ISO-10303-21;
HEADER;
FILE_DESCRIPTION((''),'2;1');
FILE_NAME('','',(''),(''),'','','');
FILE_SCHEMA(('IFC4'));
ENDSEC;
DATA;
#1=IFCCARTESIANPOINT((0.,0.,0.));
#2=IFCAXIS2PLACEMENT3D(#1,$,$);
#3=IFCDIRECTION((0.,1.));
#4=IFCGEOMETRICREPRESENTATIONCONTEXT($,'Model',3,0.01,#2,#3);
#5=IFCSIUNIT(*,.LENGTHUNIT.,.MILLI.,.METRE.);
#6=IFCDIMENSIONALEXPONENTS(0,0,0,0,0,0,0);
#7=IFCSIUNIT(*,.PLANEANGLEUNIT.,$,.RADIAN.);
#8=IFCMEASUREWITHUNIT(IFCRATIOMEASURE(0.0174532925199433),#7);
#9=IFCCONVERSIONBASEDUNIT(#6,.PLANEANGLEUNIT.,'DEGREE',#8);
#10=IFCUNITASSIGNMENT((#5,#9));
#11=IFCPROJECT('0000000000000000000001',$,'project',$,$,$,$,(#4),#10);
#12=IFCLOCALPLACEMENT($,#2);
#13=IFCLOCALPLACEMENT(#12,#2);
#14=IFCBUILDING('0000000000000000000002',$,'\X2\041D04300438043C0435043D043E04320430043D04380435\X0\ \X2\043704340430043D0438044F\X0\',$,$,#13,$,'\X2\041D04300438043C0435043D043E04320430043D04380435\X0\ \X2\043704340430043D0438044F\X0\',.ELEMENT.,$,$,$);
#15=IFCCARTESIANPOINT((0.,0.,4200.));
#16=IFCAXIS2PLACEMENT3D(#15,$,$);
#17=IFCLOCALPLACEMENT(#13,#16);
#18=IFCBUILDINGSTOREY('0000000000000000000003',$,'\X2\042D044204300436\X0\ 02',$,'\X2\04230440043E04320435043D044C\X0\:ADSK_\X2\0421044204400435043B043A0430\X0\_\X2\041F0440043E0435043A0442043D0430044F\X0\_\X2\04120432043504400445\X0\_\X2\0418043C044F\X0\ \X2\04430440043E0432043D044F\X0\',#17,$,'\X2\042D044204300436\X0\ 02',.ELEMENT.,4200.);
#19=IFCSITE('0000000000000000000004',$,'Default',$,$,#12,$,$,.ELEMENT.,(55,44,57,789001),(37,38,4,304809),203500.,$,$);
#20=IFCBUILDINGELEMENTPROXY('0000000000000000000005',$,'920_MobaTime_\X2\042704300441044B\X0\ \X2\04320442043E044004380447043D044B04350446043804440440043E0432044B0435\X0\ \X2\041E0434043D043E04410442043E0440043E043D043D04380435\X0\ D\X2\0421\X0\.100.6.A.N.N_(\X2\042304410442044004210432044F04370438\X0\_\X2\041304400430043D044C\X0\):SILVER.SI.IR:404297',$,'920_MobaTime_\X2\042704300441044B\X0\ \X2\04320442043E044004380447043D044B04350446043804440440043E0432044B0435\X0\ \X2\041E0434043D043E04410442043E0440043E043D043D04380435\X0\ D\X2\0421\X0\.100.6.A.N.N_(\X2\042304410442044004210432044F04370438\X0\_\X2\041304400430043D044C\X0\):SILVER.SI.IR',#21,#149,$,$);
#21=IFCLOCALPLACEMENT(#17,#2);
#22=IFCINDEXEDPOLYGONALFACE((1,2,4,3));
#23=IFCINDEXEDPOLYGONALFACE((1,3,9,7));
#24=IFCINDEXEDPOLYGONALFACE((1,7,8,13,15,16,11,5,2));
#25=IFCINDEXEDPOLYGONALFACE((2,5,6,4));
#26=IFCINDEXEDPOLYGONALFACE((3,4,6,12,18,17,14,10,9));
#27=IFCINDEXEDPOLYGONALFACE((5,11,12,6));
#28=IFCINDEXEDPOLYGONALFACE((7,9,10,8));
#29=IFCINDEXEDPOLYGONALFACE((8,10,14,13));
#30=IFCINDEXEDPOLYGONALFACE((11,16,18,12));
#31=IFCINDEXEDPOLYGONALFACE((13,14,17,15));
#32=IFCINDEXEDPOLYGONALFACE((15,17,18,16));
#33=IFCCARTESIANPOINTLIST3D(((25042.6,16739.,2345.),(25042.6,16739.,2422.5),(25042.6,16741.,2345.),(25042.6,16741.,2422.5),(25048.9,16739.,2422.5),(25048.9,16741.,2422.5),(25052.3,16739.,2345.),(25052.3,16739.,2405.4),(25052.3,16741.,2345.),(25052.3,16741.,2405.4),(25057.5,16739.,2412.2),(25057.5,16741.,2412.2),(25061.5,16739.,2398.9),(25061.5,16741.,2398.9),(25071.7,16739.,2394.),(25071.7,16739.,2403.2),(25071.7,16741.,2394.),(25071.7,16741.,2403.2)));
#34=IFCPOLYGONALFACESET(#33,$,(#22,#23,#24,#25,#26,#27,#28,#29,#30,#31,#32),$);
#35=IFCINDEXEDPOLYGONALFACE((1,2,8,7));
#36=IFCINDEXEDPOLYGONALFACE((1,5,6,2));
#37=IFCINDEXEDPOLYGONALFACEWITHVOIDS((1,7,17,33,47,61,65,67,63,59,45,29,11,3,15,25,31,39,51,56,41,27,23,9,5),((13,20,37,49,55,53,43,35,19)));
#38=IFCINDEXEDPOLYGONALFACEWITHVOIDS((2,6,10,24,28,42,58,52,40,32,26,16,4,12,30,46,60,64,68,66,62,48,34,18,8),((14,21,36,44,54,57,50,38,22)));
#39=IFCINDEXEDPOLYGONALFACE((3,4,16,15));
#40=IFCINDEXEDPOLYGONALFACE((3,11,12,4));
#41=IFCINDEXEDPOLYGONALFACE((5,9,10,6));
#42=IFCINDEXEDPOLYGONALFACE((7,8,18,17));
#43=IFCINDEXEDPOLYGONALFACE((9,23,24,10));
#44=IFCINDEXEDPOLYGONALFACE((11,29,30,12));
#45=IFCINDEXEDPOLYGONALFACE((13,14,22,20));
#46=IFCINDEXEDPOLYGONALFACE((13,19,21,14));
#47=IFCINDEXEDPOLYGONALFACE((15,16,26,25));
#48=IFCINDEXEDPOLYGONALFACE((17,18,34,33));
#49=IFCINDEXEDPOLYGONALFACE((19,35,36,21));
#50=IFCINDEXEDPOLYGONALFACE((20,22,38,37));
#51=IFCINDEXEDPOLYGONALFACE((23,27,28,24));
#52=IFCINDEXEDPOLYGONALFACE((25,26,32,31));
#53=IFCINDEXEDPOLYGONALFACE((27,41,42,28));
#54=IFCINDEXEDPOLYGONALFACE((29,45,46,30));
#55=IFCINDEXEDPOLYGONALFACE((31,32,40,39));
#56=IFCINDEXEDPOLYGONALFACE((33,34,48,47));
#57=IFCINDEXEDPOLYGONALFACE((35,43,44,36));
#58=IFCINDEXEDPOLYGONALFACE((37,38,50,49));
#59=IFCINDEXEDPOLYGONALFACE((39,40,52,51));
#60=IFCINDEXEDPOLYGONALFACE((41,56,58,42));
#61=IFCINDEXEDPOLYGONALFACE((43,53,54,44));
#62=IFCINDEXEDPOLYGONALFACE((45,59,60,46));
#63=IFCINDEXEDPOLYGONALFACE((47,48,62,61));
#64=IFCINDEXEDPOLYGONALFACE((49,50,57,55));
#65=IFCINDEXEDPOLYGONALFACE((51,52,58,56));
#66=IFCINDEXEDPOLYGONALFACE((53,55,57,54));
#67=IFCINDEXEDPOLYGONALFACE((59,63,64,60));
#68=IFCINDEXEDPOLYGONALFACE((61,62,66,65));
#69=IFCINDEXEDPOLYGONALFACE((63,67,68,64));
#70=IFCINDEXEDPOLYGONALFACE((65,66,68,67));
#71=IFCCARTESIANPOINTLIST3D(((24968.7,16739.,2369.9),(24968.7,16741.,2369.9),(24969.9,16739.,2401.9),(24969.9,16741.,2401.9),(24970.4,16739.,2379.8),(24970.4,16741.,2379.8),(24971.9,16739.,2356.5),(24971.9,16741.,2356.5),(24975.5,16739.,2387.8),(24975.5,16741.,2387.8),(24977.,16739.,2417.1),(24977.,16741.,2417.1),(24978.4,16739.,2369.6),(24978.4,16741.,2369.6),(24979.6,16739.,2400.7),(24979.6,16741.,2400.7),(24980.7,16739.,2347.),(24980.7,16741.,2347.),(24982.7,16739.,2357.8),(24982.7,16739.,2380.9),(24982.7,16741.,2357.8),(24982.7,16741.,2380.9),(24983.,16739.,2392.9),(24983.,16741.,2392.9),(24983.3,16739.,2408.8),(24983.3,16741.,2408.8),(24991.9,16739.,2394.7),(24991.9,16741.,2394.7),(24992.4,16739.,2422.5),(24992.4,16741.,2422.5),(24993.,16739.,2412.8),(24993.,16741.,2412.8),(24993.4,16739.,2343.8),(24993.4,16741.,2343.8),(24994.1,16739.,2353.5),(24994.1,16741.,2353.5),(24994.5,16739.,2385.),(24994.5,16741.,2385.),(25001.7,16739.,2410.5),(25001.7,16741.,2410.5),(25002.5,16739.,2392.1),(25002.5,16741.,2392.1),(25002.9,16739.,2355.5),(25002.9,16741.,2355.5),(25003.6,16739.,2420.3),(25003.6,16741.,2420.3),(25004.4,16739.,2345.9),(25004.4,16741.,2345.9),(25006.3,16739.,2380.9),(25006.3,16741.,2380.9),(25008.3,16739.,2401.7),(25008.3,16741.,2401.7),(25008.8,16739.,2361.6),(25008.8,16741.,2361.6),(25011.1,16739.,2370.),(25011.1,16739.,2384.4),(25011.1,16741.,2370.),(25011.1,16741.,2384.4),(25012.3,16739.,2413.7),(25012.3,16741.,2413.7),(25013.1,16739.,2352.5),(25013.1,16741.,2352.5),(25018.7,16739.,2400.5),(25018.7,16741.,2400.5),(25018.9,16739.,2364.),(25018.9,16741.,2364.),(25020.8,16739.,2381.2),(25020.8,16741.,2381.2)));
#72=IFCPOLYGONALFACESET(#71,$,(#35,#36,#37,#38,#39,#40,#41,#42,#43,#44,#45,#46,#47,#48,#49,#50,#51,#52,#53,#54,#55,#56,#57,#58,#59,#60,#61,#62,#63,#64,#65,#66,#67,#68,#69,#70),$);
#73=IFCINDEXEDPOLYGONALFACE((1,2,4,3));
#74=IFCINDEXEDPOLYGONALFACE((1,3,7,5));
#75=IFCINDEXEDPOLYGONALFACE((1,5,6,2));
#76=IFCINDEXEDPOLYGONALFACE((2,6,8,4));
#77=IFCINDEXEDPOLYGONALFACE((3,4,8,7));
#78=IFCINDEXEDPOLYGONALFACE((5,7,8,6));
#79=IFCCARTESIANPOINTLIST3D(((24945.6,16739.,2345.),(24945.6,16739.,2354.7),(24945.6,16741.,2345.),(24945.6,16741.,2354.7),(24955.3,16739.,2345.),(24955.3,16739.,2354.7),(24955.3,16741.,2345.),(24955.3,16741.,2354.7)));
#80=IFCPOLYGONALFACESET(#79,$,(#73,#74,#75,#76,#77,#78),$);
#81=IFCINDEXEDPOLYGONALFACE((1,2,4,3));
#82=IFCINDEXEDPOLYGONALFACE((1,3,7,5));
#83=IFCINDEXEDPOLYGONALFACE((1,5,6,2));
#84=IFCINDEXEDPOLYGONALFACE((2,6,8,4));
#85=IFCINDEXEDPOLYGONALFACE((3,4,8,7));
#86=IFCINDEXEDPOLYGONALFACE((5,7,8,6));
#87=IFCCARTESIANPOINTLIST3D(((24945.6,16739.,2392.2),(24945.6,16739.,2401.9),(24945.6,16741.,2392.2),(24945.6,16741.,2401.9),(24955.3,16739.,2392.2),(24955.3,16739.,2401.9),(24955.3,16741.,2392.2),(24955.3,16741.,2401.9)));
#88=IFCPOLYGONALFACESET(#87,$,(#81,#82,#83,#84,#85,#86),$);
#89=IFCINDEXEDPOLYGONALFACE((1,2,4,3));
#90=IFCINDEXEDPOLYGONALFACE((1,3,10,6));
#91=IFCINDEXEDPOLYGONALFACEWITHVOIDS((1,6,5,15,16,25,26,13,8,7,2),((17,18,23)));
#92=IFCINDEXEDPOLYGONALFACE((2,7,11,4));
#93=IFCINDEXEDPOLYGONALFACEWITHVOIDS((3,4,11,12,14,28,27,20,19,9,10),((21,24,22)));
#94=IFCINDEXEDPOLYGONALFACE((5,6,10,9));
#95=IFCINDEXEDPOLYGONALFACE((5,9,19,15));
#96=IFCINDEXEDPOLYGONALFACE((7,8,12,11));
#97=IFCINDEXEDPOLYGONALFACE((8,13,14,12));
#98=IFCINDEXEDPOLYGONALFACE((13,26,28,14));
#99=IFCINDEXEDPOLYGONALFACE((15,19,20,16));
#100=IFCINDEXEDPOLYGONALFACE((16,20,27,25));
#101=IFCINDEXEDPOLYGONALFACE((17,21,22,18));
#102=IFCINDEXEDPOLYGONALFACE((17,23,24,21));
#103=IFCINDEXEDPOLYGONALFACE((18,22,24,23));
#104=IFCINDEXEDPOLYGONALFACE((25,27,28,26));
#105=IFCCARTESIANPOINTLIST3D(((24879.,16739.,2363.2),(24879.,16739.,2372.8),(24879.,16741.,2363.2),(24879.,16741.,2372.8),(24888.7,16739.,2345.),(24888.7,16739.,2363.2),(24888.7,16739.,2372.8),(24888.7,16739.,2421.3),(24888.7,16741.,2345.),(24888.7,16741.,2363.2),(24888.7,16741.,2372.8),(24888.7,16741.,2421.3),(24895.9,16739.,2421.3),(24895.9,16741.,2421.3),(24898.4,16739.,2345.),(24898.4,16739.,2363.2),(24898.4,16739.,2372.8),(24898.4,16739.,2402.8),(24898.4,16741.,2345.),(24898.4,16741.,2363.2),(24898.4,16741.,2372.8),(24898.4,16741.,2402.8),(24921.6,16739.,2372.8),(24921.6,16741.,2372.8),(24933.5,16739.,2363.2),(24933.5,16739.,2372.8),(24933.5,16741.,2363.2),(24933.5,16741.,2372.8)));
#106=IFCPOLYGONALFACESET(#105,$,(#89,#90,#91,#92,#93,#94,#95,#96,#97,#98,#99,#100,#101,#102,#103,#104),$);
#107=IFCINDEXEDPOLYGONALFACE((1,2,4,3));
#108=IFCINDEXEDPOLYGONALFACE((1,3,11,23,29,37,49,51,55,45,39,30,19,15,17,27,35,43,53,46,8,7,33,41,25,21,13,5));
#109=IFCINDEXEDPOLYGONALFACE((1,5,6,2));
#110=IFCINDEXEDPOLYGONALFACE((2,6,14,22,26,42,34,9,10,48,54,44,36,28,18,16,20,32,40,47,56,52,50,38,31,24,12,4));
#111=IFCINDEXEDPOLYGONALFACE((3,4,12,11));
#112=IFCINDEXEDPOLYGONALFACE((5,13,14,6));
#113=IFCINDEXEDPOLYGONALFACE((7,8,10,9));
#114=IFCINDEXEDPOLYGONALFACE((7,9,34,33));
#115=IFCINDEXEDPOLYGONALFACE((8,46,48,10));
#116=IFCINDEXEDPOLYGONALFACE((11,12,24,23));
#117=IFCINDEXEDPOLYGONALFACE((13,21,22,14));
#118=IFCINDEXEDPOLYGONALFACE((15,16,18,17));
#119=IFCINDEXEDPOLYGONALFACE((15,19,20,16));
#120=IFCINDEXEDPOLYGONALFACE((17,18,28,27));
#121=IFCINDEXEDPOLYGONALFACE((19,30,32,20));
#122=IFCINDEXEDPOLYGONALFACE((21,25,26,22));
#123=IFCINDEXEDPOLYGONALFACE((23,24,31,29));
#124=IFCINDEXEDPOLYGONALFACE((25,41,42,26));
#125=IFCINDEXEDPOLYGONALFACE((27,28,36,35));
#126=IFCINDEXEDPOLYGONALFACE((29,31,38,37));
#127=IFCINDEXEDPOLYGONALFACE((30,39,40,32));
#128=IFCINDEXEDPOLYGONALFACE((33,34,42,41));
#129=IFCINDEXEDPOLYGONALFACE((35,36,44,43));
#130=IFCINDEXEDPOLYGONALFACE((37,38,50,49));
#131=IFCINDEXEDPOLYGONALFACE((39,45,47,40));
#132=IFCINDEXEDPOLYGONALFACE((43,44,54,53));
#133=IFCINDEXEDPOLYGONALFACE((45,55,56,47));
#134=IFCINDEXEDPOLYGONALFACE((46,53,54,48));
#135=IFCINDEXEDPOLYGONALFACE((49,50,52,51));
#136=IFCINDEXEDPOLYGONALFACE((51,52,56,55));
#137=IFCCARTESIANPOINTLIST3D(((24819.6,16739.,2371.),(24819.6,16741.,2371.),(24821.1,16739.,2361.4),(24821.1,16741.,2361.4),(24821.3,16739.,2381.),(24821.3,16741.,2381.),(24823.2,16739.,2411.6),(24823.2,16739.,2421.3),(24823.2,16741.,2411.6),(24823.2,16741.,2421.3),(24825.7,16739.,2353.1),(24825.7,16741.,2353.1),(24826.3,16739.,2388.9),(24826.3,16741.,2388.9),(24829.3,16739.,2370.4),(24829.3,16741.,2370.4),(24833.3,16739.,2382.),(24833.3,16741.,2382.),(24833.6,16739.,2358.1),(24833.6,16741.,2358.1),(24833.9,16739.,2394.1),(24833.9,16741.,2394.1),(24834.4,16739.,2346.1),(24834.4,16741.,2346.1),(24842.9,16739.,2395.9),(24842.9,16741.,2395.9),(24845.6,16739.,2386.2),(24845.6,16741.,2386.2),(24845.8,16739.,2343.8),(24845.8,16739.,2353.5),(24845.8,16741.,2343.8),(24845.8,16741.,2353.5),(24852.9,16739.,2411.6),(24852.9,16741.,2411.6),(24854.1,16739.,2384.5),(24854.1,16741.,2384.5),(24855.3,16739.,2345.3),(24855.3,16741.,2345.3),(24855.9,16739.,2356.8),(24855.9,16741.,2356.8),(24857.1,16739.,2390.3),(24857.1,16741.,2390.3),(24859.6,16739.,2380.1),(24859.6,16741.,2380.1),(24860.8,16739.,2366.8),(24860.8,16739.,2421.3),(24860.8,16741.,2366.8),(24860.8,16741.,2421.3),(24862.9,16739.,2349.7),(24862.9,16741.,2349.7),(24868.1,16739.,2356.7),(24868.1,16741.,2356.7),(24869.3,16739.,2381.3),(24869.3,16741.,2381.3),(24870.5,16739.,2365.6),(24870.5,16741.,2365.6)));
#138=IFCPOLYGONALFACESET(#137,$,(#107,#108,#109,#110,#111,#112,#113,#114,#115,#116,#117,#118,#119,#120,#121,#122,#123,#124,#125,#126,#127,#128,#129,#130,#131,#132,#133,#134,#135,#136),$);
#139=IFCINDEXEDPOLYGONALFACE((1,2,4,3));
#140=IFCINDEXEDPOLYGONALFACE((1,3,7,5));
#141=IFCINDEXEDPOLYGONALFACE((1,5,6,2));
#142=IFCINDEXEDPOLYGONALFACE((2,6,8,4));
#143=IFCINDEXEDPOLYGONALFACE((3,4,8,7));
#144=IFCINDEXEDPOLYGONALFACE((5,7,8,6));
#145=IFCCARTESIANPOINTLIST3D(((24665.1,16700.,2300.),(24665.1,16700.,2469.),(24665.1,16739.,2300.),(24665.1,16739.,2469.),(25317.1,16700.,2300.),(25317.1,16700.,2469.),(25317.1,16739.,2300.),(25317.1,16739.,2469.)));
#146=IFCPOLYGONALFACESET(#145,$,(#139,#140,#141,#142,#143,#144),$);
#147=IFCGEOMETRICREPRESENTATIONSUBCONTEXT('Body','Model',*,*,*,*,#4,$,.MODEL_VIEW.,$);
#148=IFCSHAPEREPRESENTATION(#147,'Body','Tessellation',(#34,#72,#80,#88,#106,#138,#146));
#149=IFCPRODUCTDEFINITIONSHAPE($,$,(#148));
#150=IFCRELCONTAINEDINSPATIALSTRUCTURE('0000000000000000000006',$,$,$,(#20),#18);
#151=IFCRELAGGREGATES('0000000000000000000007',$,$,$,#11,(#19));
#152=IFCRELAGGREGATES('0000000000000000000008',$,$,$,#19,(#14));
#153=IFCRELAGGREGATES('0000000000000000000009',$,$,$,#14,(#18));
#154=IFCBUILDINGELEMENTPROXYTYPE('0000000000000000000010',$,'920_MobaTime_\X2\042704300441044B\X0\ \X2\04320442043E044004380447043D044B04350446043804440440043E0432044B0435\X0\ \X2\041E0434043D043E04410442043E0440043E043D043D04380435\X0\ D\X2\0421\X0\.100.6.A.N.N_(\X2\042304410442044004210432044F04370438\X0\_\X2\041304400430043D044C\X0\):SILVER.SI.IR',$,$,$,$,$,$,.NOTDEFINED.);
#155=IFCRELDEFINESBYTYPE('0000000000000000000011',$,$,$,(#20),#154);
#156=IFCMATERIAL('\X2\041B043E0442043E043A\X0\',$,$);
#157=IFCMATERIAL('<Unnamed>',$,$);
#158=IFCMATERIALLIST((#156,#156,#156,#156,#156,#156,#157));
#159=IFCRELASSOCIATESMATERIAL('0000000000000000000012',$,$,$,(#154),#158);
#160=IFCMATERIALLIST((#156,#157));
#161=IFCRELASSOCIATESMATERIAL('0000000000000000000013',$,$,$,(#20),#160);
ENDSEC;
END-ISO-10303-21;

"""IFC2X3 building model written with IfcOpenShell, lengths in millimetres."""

from ifc_helpers import new_model, entity, si_unit, converted_unit, direction, frame, origin, origin_2d_with_axis, place, context, subcontext, project, spatial, polyline, rectangle, outline, extrude, source, transform, mapped, material, material_list, type_object, type_shapes, element, save


model = new_model("IFC2X3")

# Units and contexts
model_context = context("Model", 3, precision=0.01, world=origin(), true_north=direction((0.0, 1.0)))
body_context = subcontext(model_context, "Body", "Model", "MODEL_VIEW")
ifc_project = project(units=[si_unit("LENGTHUNIT", "METRE", prefix="MILLI"), converted_unit("PLANEANGLEUNIT", "DEGREE", entity("IfcRatioMeasure", 0.0174532925199433), si_unit("PLANEANGLEUNIT", "RADIAN"), dimensions=[0, 0, 0, 0, 0, 0, 0])], contexts=[model_context])

# Site, building, storey
site_placement = place(None, frame((0.0, 0.0, 0.0)))
site = spatial("IfcSite", under=ifc_project, at=site_placement, Name="Default", CompositionType="ELEMENT", RefLatitude=(55, 44, 57, 789001), RefLongitude=(37, 38, 4, 304809), RefElevation=203500.0)
building_placement = place(site_placement, origin())
building = spatial("IfcBuilding", under=site, at=building_placement, Name="Наименование здания", LongName="Наименование здания", CompositionType="ELEMENT")
storey_placement = place(building_placement, frame((0.0, 0.0, 4200.0)))
storey = spatial("IfcBuildingStorey", under=building, at=storey_placement, Name="Этаж 02", ObjectType="Уровень:ADSK_Стрелка_Проектная_Вверх_Имя уровня", LongName="Этаж 02", CompositionType="ELEMENT", Elevation=4200.0)

# Building element proxy
ifc_material_1 = material(Name="Лоток")
ifc_material_2 = material(Name="<Unnamed>")
ifc_material_list_1 = material_list([ifc_material_1, ifc_material_1, ifc_material_1, ifc_material_1, ifc_material_1, ifc_material_1, ifc_material_2])
building_element_proxy_type_1 = type_object("IfcBuildingElementProxyType", Name="920_MobaTime_Часы вторичныецифровые Односторонние DС.100.6.A.N.N_(УстрСвязи_Грань):SILVER.SI.IR", PredefinedType="NOTDEFINED", material=ifc_material_list_1)
shared_shape_1 = source(origin(), body_context, "Body", "SweptSolid", [
    extrude(outline(polyline([(-49.3, -13.1), (28.2, -13.1), (28.2, -6.8), (17.9, 1.8), (8.9, 16.0), (-0.3, 16.0), (4.6, 5.8), (11.1, -3.4), (-49.3, -3.4), (-49.3, -13.1)])), frame((-64.6, 9.8, 39.0), z_axis=(0.0, 0.0, 1.0), x_axis=(0.0, 1.0, 0.0)), (0.0, 0.0, 1.0), 2.0),
    extrude(outline(polyline([(2.2, -27.6), (19.0, -27.6), (30.5, -16.1), (33.3, -4.9), (31.0, 5.8), (21.8, 17.2), (5.2, 27.3), (-11.1, 33.0), (-24.0, 32.7), (-33.6, 27.6), (-40.3, 18.6), (-42.8, 5.7), (-38.0, -6.3), (-27.2, -15.0), (-17.5, -17.7), (-8.2, -16.4), (-0.3, -11.9), (5.1, -4.5), (7.3, 6.2), (4.0, 17.2), (18.5, 7.3), (23.6, -2.4), (22.0, -11.4), (14.2, -18.4), (5.3, -18.3), (2.2, -27.6)]), holes=[polyline([(-9.0, 23.3), (-1.3, 14.4), (-2.6, 2.0), (-11.4, -7.0), (-23.4, -6.1), (-32.2, 2.9), (-31.2, 15.1), (-25.6, 22.1), (-17.5, 24.9), (-9.0, 23.3)])]), frame((-2.7, 3.6, 39.0), z_axis=(0.0, 0.0, 1.0), x_axis=(-0.427649, 0.903945, 0.0)), (0.0, 0.0, 1.0), 2.0),
    extrude(rectangle(XDim=9.7, YDim=9.7, at=origin_2d_with_axis()), frame((40.6, -34.7, 39.0)), (0.0, 0.0, 1.0), 2.0),
    extrude(rectangle(XDim=9.7, YDim=9.7, at=origin_2d_with_axis()), frame((40.6, 12.6, 39.0)), (0.0, 0.0, 1.0), 2.0),
    extrude(outline(polyline([(-0.9, -28.1), (8.8, -28.1), (8.8, -9.9), (18.5, -9.9), (18.5, -0.2), (8.8, -0.2), (8.8, 48.3), (1.5, 48.3), (-36.0, -0.2), (-36.0, -9.9), (-0.9, -9.9), (-0.9, -28.1)]), holes=[polyline([(-0.9, -0.2), (-24.1, -0.2), (-0.9, 29.7), (-0.9, -0.2)])]), frame((93.6, -11.4, 39.0)), (0.0, 0.0, 1.0), 2.0),
    extrude(outline(polyline([(3.3, -28.3), (12.5, -28.3), (20.5, -25.0), (26.8, -18.8), (30.7, -10.0), (31.4, 1.6), (26.9, 11.8), (20.1, 18.4), (11.1, 22.3), (1.0, 23.3), (-7.9, 20.4), (-14.9, 14.5), (-18.9, 6.2), (-17.1, -9.0), (-36.7, 0.5), (-29.1, 29.3), (-38.5, 31.7), (-48.1, -4.6), (-11.6, -23.0), (-8.0, -14.0), (-10.8, -7.6), (-10.2, 1.1), (-3.0, 11.8), (9.2, 12.8), (20.0, 5.4), (21.3, -7.5), (15.5, -16.4), (4.6, -18.6), (3.3, -28.3)])), frame((147.1, -8.5, 39.0), z_axis=(0.0, 0.0, 1.0), x_axis=(0.256974, -0.966418, 0.0)), (0.0, 0.0, 1.0), 2.0),
    extrude(rectangle(XDim=652.0, YDim=169.0, at=origin_2d_with_axis()), frame((0.0, 0.0, 0.0), z_axis=(0.0, 0.0, 1.0), x_axis=(-1.0, 0.0, 0.0)), (0.0, 0.0, 1.0), 39.0),
])
type_shapes(building_element_proxy_type_1, [shared_shape_1])
ifc_material_list_2 = material_list([ifc_material_1, ifc_material_2])
proxy_1_placement = place(storey_placement, frame((24991.1, 16700.0, 2384.5), z_axis=(0.0, 1.0, 0.0), x_axis=(-1.0, 0.0, 0.0)))
element("IfcBuildingElementProxy", 1, at=proxy_1_placement, inside=storey, type_object=building_element_proxy_type_1, material=ifc_material_list_2, Name="920_MobaTime_Часы вторичныецифровые Односторонние DС.100.6.A.N.N_(УстрСвязи_Грань):SILVER.SI.IR:404297", ObjectType="920_MobaTime_Часы вторичныецифровые Односторонние DС.100.6.A.N.N_(УстрСвязи_Грань):SILVER.SI.IR", context=body_context, shape_type="MappedRepresentation", body=[
    mapped(shared_shape_1, transform((0.0, 0.0, 0.0), scale=1.0)),
])

save(model, "model.ifc")
